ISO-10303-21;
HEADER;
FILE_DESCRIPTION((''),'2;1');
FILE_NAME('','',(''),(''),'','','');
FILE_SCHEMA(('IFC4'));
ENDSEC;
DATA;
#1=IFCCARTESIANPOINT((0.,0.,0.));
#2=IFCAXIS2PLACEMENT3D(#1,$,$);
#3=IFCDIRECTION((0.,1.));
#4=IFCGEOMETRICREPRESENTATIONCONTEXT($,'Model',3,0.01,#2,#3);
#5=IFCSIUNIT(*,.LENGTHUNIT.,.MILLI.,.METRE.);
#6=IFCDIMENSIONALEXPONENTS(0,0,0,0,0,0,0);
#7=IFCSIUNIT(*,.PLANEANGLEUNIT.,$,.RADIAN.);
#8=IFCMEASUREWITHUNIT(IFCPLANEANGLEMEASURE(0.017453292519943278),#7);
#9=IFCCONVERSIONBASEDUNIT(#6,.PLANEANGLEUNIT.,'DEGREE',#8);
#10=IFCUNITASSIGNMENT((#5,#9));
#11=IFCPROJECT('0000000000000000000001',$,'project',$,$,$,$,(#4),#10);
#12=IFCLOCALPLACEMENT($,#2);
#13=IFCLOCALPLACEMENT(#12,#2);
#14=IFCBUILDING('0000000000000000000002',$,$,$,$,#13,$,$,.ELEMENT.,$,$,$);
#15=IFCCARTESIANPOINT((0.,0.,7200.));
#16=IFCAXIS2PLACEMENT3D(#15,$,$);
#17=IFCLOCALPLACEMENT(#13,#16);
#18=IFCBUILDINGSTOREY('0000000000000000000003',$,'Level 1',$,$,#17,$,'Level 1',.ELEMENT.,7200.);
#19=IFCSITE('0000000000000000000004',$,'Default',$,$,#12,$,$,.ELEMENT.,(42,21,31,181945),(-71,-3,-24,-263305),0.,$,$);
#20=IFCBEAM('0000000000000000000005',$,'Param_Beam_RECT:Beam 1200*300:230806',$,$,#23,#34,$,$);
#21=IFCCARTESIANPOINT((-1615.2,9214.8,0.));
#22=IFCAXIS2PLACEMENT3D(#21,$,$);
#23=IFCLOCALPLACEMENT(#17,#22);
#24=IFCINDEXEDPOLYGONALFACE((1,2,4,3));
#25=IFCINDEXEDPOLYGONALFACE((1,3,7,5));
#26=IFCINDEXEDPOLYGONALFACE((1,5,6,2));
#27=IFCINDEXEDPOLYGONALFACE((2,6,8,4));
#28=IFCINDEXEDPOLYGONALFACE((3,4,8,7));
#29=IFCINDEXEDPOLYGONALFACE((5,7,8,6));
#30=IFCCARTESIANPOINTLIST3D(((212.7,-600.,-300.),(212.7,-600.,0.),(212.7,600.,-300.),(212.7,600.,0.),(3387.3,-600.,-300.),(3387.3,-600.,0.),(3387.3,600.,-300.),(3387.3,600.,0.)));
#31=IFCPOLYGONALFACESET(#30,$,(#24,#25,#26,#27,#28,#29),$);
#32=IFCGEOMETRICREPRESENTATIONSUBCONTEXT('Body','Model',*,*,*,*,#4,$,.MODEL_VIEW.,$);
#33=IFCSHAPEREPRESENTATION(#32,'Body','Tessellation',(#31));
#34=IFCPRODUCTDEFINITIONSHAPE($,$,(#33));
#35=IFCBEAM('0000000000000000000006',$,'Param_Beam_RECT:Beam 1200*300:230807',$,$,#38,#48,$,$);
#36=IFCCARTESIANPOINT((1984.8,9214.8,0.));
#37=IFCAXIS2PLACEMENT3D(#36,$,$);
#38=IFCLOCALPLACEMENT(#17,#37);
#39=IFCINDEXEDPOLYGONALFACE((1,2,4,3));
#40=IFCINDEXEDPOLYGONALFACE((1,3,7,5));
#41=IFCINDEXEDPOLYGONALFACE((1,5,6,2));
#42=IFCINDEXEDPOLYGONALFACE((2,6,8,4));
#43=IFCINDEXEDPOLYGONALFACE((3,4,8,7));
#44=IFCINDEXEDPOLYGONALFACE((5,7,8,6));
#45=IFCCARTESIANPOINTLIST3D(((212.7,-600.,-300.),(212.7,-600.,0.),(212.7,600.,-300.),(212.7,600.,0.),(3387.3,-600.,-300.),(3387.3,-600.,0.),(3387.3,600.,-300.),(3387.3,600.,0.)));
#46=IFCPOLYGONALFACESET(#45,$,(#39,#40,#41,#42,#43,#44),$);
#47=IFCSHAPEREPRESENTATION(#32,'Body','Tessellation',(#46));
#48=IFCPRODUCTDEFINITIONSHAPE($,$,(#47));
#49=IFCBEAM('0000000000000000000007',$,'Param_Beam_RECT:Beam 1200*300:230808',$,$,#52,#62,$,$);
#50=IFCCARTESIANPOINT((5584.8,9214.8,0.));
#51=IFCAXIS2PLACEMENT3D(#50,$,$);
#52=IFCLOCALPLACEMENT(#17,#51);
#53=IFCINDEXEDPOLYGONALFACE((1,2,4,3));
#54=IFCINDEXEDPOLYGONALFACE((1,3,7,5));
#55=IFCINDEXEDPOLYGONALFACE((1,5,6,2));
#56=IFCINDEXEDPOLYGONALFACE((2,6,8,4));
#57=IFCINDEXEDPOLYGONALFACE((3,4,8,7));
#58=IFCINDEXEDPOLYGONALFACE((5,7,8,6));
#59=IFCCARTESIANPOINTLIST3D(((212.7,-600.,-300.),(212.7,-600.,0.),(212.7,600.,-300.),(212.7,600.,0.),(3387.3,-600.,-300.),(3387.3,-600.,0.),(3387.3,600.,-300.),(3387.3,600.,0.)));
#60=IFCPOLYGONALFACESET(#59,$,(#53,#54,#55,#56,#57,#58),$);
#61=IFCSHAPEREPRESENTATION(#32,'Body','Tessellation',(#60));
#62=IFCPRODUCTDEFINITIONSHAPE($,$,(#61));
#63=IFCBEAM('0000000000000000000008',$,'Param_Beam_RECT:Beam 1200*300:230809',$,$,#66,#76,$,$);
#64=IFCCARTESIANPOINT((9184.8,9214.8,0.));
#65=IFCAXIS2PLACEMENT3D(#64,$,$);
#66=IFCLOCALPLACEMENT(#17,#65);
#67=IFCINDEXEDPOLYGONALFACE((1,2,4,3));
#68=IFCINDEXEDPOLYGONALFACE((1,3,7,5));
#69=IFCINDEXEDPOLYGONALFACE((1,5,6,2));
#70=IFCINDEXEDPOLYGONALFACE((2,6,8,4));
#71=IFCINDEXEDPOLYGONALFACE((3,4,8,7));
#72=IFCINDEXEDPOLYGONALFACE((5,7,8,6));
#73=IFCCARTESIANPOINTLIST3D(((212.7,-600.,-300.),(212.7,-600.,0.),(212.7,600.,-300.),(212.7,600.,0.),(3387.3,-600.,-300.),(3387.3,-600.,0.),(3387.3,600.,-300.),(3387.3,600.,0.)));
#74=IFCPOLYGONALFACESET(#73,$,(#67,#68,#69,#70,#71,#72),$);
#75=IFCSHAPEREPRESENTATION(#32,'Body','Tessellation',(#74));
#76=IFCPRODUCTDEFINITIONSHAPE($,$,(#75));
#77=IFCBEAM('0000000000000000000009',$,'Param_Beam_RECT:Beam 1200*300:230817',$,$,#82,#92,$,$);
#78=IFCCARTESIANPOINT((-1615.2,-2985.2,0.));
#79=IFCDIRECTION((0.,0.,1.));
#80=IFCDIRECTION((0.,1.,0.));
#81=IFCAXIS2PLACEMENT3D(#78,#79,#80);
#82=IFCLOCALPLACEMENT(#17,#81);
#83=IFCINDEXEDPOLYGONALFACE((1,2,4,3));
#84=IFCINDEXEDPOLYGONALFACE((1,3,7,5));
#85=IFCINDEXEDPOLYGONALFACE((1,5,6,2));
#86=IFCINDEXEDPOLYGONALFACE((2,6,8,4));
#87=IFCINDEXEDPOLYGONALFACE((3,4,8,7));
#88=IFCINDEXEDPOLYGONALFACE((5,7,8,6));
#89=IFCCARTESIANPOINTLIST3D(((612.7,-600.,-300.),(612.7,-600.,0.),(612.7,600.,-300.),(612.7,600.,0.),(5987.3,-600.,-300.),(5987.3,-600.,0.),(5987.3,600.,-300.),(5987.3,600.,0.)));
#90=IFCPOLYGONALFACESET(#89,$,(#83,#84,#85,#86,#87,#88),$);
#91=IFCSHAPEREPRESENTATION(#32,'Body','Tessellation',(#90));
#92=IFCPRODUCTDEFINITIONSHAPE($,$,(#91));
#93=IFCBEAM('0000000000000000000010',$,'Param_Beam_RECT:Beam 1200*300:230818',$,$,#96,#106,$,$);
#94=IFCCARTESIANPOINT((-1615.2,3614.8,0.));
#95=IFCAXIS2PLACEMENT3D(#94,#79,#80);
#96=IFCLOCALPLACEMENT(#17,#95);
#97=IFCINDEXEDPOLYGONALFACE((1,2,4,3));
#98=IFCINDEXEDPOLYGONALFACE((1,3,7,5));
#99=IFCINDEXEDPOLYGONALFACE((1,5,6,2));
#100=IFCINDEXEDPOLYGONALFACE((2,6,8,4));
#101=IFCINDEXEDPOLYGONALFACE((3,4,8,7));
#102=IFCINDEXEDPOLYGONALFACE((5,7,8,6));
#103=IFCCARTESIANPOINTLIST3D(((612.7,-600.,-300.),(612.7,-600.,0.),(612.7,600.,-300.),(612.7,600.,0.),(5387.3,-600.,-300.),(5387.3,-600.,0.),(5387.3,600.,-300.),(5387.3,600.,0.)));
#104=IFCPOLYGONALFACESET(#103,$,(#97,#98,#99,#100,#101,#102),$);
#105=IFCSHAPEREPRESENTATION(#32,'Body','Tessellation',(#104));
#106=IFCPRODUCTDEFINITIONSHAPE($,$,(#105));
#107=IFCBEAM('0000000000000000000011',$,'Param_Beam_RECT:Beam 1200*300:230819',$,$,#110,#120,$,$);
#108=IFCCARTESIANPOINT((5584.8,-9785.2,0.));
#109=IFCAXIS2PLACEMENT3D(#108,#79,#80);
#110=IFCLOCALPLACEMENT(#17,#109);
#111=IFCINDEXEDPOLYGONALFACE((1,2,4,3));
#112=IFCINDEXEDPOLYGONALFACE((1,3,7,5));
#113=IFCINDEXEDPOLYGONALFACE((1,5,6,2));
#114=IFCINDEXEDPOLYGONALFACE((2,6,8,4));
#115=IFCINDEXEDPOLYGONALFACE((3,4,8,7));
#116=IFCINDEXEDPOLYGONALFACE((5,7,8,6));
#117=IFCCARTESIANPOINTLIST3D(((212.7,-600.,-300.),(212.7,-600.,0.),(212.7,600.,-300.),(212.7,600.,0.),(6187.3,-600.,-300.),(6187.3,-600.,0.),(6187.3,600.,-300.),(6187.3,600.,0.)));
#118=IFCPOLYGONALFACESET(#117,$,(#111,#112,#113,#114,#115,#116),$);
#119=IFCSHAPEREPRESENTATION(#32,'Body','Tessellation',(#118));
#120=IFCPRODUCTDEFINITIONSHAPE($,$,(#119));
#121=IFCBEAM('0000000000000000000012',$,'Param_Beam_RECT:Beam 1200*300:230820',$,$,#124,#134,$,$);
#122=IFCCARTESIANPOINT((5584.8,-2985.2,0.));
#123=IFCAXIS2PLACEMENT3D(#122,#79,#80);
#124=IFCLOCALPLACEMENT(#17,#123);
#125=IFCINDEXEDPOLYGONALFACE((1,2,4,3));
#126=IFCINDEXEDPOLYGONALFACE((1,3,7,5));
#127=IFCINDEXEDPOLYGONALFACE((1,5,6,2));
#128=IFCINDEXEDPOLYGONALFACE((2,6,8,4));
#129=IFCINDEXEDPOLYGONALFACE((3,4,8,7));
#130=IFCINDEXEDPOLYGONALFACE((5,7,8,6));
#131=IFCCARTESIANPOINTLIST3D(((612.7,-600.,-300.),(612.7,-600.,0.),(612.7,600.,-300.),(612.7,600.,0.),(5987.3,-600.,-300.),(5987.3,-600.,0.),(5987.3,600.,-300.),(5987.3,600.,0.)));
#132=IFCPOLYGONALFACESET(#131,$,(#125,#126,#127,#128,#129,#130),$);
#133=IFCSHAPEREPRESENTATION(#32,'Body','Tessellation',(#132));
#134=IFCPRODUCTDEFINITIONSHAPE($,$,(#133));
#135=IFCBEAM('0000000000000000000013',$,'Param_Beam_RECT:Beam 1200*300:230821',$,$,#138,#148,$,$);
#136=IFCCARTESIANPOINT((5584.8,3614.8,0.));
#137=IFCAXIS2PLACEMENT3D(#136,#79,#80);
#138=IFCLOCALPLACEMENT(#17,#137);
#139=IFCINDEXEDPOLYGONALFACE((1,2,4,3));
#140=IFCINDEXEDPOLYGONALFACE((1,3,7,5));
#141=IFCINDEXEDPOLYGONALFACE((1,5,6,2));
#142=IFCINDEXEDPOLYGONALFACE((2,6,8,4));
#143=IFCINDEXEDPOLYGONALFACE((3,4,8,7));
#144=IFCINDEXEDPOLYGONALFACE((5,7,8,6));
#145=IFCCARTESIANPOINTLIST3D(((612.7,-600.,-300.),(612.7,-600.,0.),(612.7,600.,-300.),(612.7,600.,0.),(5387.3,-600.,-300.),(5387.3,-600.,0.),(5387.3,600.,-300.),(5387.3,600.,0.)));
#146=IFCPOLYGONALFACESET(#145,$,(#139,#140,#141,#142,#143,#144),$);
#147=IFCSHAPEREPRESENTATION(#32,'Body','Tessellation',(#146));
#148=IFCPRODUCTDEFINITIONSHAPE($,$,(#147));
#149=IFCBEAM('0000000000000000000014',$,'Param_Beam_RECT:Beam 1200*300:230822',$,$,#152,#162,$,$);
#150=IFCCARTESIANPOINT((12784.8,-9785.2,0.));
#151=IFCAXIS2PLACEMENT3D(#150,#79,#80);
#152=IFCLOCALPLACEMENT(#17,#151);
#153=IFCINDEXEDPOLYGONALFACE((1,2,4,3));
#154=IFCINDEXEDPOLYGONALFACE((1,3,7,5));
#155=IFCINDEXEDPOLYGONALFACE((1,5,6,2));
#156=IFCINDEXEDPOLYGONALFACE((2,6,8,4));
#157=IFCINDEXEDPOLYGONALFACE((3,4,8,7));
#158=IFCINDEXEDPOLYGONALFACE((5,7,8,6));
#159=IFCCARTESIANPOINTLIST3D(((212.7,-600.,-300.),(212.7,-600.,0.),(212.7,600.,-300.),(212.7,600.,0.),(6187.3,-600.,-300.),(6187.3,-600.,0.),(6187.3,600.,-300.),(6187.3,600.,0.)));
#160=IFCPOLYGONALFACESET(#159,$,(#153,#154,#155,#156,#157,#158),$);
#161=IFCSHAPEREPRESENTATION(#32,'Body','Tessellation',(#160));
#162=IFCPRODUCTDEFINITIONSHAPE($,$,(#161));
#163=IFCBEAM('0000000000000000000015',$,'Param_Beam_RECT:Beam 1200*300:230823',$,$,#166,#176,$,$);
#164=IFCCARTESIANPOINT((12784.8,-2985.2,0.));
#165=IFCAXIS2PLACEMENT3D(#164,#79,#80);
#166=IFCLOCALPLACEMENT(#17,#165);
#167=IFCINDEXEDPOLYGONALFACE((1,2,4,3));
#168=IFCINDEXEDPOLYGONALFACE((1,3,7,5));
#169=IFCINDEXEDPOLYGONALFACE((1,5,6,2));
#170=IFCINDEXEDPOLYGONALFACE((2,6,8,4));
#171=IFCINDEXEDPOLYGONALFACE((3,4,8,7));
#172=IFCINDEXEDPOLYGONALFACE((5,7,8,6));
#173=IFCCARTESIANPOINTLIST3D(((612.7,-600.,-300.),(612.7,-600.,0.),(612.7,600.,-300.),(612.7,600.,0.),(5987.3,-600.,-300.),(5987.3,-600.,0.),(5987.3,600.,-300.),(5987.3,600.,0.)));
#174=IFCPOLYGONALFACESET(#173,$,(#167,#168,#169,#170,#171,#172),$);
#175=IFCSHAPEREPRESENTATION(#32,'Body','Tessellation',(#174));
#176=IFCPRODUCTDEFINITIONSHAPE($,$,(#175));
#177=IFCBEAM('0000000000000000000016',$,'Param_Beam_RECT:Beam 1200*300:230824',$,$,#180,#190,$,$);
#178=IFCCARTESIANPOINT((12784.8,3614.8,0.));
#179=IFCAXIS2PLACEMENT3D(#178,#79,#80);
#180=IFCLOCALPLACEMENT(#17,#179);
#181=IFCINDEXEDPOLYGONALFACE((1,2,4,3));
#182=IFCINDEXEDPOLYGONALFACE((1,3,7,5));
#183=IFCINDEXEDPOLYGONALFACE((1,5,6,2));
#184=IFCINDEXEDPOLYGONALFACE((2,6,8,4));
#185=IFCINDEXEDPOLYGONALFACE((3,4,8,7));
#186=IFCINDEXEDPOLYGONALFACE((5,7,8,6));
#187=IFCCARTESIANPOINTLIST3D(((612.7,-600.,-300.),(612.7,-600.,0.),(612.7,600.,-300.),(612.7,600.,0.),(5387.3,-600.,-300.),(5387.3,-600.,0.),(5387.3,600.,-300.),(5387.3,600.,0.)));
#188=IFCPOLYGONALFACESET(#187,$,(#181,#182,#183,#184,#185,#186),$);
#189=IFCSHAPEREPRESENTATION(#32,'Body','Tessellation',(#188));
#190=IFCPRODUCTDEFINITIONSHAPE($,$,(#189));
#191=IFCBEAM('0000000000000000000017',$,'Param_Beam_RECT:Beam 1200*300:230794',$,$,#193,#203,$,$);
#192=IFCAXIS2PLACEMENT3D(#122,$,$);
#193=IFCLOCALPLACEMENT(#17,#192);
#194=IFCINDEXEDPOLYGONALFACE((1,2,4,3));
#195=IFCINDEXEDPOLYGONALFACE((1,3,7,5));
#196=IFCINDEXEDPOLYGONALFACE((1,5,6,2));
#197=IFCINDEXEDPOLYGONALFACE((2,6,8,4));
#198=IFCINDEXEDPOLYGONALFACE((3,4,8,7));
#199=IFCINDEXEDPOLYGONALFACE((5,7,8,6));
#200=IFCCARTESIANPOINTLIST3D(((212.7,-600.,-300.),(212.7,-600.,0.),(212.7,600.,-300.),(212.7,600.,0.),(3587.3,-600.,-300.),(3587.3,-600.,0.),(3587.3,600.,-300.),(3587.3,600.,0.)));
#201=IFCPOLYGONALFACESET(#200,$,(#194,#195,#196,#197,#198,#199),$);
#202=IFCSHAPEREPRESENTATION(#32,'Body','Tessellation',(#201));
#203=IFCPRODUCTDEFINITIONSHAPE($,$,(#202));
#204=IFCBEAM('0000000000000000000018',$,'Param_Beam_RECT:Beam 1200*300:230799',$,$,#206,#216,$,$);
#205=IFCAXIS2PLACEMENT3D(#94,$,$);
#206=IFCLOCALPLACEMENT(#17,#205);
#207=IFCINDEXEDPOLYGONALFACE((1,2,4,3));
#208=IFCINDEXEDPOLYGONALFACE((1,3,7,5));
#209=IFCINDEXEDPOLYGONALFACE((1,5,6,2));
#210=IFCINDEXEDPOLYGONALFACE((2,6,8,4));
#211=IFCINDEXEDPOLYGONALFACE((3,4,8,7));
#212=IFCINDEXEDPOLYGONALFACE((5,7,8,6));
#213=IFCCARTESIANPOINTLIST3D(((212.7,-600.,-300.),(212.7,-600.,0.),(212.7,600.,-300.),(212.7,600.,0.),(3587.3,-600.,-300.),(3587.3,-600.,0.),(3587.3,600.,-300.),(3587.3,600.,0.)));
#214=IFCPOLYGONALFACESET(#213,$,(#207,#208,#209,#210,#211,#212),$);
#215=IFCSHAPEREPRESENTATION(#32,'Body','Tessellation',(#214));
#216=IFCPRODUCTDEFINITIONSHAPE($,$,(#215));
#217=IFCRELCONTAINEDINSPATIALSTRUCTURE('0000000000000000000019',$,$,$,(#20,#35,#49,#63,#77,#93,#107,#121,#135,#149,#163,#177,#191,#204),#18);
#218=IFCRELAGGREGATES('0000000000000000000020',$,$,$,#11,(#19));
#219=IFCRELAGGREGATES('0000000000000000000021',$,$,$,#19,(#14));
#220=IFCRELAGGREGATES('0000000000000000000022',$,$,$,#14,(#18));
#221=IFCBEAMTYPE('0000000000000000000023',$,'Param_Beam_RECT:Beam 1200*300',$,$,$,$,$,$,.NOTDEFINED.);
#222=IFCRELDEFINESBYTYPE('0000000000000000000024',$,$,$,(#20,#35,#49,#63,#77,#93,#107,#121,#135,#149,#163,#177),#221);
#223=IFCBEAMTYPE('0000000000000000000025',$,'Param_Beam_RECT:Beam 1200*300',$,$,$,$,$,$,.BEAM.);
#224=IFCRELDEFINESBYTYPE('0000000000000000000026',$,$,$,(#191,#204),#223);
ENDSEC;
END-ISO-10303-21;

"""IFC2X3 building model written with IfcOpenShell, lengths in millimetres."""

from ifc_helpers import new_model, entity, si_unit, converted_unit, direction, frame, frame_2d, origin, origin_2d_with_axis, place, context, subcontext, project, spatial, rectangle, extrude, type_object, element, save


model = new_model("IFC2X3")

# Units and contexts
model_context = context("Model", 3, precision=0.01, world=origin(), true_north=direction((0.0, 1.0)))
body_context = subcontext(model_context, "Body", "Model", "MODEL_VIEW")
ifc_project = project(units=[si_unit("LENGTHUNIT", "METRE", prefix="MILLI"), converted_unit("PLANEANGLEUNIT", "DEGREE", entity("IfcPlaneAngleMeasure", 0.017453292519943278), si_unit("PLANEANGLEUNIT", "RADIAN"), dimensions=[0, 0, 0, 0, 0, 0, 0])], contexts=[model_context])

# Site, building, storey
site_placement = place(None, origin())
site = spatial("IfcSite", under=ifc_project, at=site_placement, Name="Default", CompositionType="ELEMENT", RefLatitude=(42, 21, 31, 181945), RefLongitude=(-71, -3, -24, -263305), RefElevation=0.0)
building_placement = place(site_placement, origin())
building = spatial("IfcBuilding", under=site, at=building_placement, CompositionType="ELEMENT")
storey_placement = place(building_placement, frame((0.0, 0.0, 7200.0)))
storey = spatial("IfcBuildingStorey", under=building, at=storey_placement, Name="Level 1", LongName="Level 1", CompositionType="ELEMENT", Elevation=7200.0)

# Beams
beam_type_1 = type_object("IfcBeamType", Name="Param_Beam_RECT:Beam 1200*300", PredefinedType="NOTDEFINED")
beam_1_placement = place(storey_placement, frame((-1615.2, 9214.8, 0.0)))
element("IfcBeam", 1, at=beam_1_placement, inside=storey, type_object=beam_type_1, Name="Param_Beam_RECT:Beam 1200*300:230806", context=body_context, shape_type="SweptSolid", body=[
    extrude(rectangle(XDim=300.0, YDim=1200.0, at=frame_2d((0.0, 0.0), x_axis=(1.0, 0.0))), frame((212.7, 0.0, -150.0), z_axis=(1.0, 0.0, 0.0), x_axis=(0.0, 0.0, -1.0)), (0.0, 0.0, 1.0), 3174.6),
])
beam_2_placement = place(storey_placement, frame((1984.8, 9214.8, 0.0)))
element("IfcBeam", 2, at=beam_2_placement, inside=storey, type_object=beam_type_1, Name="Param_Beam_RECT:Beam 1200*300:230807", context=body_context, shape_type="SweptSolid", body=[
    extrude(rectangle(XDim=300.0, YDim=1200.0, at=origin_2d_with_axis()), frame((212.7, 0.0, -150.0), z_axis=(1.0, 0.0, 0.0), x_axis=(0.0, 0.0, -1.0)), (0.0, 0.0, 1.0), 3174.6),
])
for number, where, name in (
    (3, (5584.8, 9214.8, 0.0), "Param_Beam_RECT:Beam 1200*300:230808"),
    (4, (9184.8, 9214.8, 0.0), "Param_Beam_RECT:Beam 1200*300:230809"),
):
    element("IfcBeam", number, at=place(storey_placement, frame(where)), inside=storey, type_object=beam_type_1, Name=name, context=body_context, shape_type="SweptSolid", body=[
        extrude(rectangle(XDim=300.0, YDim=1200.0, at=frame_2d((0.0, 0.0), x_axis=(1.0, 0.0))), frame((212.7, 0.0, -150.0), z_axis=(1.0, 0.0, 0.0), x_axis=(0.0, 0.0, -1.0)), (0.0, 0.0, 1.0), 3174.6),
    ])
beam_3_placement = place(storey_placement, frame((-1615.2, -2985.2, 0.0), z_axis=(0.0, 0.0, 1.0), x_axis=(0.0, 1.0, 0.0)))
element("IfcBeam", 5, at=beam_3_placement, inside=storey, type_object=beam_type_1, Name="Param_Beam_RECT:Beam 1200*300:230817", context=body_context, shape_type="SweptSolid", body=[
    extrude(rectangle(XDim=300.0, YDim=1200.0, at=frame_2d((0.0, 0.0), x_axis=(1.0, 0.0))), frame((612.7, 0.0, -150.0), z_axis=(1.0, 0.0, 0.0), x_axis=(0.0, 0.0, -1.0)), (0.0, 0.0, 1.0), 5374.6),
])
beam_4_placement = place(storey_placement, frame((-1615.2, 3614.8, 0.0), z_axis=(0.0, 0.0, 1.0), x_axis=(0.0, 1.0, 0.0)))
element("IfcBeam", 6, at=beam_4_placement, inside=storey, type_object=beam_type_1, Name="Param_Beam_RECT:Beam 1200*300:230818", context=body_context, shape_type="SweptSolid", body=[
    extrude(rectangle(XDim=300.0, YDim=1200.0, at=frame_2d((0.0, 0.0), x_axis=(1.0, 0.0))), frame((612.7, 0.0, -150.0), z_axis=(1.0, 0.0, 0.0), x_axis=(0.0, 0.0, -1.0)), (0.0, 0.0, 1.0), 4774.6),
])
beam_5_placement = place(storey_placement, frame((5584.8, -9785.2, 0.0), z_axis=(0.0, 0.0, 1.0), x_axis=(0.0, 1.0, 0.0)))
element("IfcBeam", 7, at=beam_5_placement, inside=storey, type_object=beam_type_1, Name="Param_Beam_RECT:Beam 1200*300:230819", context=body_context, shape_type="SweptSolid", body=[
    extrude(rectangle(XDim=300.0, YDim=1200.0, at=frame_2d((0.0, 0.0), x_axis=(1.0, 0.0))), frame((212.7, 0.0, -150.0), z_axis=(1.0, 0.0, 0.0), x_axis=(0.0, 0.0, -1.0)), (0.0, 0.0, 1.0), 5974.6),
])
beam_6_placement = place(storey_placement, frame((5584.8, -2985.2, 0.0), z_axis=(0.0, 0.0, 1.0), x_axis=(0.0, 1.0, 0.0)))
element("IfcBeam", 8, at=beam_6_placement, inside=storey, type_object=beam_type_1, Name="Param_Beam_RECT:Beam 1200*300:230820", context=body_context, shape_type="SweptSolid", body=[
    extrude(rectangle(XDim=300.0, YDim=1200.0, at=frame_2d((0.0, 0.0), x_axis=(1.0, 0.0))), frame((612.7, 0.0, -150.0), z_axis=(1.0, 0.0, 0.0), x_axis=(0.0, 0.0, -1.0)), (0.0, 0.0, 1.0), 5374.6),
])
beam_7_placement = place(storey_placement, frame((5584.8, 3614.8, 0.0), z_axis=(0.0, 0.0, 1.0), x_axis=(0.0, 1.0, 0.0)))
element("IfcBeam", 9, at=beam_7_placement, inside=storey, type_object=beam_type_1, Name="Param_Beam_RECT:Beam 1200*300:230821", context=body_context, shape_type="SweptSolid", body=[
    extrude(rectangle(XDim=300.0, YDim=1200.0, at=frame_2d((0.0, 0.0), x_axis=(1.0, 0.0))), frame((612.7, 0.0, -150.0), z_axis=(1.0, 0.0, 0.0), x_axis=(0.0, 0.0, -1.0)), (0.0, 0.0, 1.0), 4774.6),
])
beam_8_placement = place(storey_placement, frame((12784.8, -9785.2, 0.0), z_axis=(0.0, 0.0, 1.0), x_axis=(0.0, 1.0, 0.0)))
element("IfcBeam", 10, at=beam_8_placement, inside=storey, type_object=beam_type_1, Name="Param_Beam_RECT:Beam 1200*300:230822", context=body_context, shape_type="SweptSolid", body=[
    extrude(rectangle(XDim=300.0, YDim=1200.0, at=origin_2d_with_axis()), frame((212.7, 0.0, -150.0), z_axis=(1.0, 0.0, 0.0), x_axis=(0.0, 0.0, -1.0)), (0.0, 0.0, 1.0), 5974.6),
])
beam_9_placement = place(storey_placement, frame((12784.8, -2985.2, 0.0), z_axis=(0.0, 0.0, 1.0), x_axis=(0.0, 1.0, 0.0)))
element("IfcBeam", 11, at=beam_9_placement, inside=storey, type_object=beam_type_1, Name="Param_Beam_RECT:Beam 1200*300:230823", context=body_context, shape_type="SweptSolid", body=[
    extrude(rectangle(XDim=300.0, YDim=1200.0, at=frame_2d((0.0, 0.0), x_axis=(1.0, 0.0))), frame((612.7, 0.0, -150.0), z_axis=(1.0, 0.0, 0.0), x_axis=(0.0, 0.0, -1.0)), (0.0, 0.0, 1.0), 5374.6),
])
beam_10_placement = place(storey_placement, frame((12784.8, 3614.8, 0.0), z_axis=(0.0, 0.0, 1.0), x_axis=(0.0, 1.0, 0.0)))
element("IfcBeam", 12, at=beam_10_placement, inside=storey, type_object=beam_type_1, Name="Param_Beam_RECT:Beam 1200*300:230824", context=body_context, shape_type="SweptSolid", body=[
    extrude(rectangle(XDim=300.0, YDim=1200.0, at=origin_2d_with_axis()), frame((612.7, 0.0, -150.0), z_axis=(1.0, 0.0, 0.0), x_axis=(0.0, 0.0, -1.0)), (0.0, 0.0, 1.0), 4774.6),
])
beam_type_2 = type_object("IfcBeamType", Name="Param_Beam_RECT:Beam 1200*300", PredefinedType="BEAM")
beam_11_placement = place(storey_placement, frame((5584.8, -2985.2, 0.0)))
element("IfcBeam", 13, at=beam_11_placement, inside=storey, type_object=beam_type_2, Name="Param_Beam_RECT:Beam 1200*300:230794", context=body_context, shape_type="SweptSolid", body=[
    extrude(rectangle(XDim=300.0, YDim=1200.0, at=frame_2d((0.0, 0.0), x_axis=(1.0, 0.0))), frame((212.7, 0.0, -150.0), z_axis=(1.0, 0.0, 0.0), x_axis=(0.0, 0.0, -1.0)), (0.0, 0.0, 1.0), 3374.6),
])
beam_12_placement = place(storey_placement, frame((-1615.2, 3614.8, 0.0)))
element("IfcBeam", 14, at=beam_12_placement, inside=storey, type_object=beam_type_2, Name="Param_Beam_RECT:Beam 1200*300:230799", context=body_context, shape_type="SweptSolid", body=[
    extrude(rectangle(XDim=300.0, YDim=1200.0, at=frame_2d((0.0, 0.0), x_axis=(1.0, 0.0))), frame((212.7, 0.0, -150.0), z_axis=(1.0, 0.0, 0.0), x_axis=(0.0, 0.0, -1.0)), (0.0, 0.0, 1.0), 3374.6),
])

save(model, "model.ifc")
